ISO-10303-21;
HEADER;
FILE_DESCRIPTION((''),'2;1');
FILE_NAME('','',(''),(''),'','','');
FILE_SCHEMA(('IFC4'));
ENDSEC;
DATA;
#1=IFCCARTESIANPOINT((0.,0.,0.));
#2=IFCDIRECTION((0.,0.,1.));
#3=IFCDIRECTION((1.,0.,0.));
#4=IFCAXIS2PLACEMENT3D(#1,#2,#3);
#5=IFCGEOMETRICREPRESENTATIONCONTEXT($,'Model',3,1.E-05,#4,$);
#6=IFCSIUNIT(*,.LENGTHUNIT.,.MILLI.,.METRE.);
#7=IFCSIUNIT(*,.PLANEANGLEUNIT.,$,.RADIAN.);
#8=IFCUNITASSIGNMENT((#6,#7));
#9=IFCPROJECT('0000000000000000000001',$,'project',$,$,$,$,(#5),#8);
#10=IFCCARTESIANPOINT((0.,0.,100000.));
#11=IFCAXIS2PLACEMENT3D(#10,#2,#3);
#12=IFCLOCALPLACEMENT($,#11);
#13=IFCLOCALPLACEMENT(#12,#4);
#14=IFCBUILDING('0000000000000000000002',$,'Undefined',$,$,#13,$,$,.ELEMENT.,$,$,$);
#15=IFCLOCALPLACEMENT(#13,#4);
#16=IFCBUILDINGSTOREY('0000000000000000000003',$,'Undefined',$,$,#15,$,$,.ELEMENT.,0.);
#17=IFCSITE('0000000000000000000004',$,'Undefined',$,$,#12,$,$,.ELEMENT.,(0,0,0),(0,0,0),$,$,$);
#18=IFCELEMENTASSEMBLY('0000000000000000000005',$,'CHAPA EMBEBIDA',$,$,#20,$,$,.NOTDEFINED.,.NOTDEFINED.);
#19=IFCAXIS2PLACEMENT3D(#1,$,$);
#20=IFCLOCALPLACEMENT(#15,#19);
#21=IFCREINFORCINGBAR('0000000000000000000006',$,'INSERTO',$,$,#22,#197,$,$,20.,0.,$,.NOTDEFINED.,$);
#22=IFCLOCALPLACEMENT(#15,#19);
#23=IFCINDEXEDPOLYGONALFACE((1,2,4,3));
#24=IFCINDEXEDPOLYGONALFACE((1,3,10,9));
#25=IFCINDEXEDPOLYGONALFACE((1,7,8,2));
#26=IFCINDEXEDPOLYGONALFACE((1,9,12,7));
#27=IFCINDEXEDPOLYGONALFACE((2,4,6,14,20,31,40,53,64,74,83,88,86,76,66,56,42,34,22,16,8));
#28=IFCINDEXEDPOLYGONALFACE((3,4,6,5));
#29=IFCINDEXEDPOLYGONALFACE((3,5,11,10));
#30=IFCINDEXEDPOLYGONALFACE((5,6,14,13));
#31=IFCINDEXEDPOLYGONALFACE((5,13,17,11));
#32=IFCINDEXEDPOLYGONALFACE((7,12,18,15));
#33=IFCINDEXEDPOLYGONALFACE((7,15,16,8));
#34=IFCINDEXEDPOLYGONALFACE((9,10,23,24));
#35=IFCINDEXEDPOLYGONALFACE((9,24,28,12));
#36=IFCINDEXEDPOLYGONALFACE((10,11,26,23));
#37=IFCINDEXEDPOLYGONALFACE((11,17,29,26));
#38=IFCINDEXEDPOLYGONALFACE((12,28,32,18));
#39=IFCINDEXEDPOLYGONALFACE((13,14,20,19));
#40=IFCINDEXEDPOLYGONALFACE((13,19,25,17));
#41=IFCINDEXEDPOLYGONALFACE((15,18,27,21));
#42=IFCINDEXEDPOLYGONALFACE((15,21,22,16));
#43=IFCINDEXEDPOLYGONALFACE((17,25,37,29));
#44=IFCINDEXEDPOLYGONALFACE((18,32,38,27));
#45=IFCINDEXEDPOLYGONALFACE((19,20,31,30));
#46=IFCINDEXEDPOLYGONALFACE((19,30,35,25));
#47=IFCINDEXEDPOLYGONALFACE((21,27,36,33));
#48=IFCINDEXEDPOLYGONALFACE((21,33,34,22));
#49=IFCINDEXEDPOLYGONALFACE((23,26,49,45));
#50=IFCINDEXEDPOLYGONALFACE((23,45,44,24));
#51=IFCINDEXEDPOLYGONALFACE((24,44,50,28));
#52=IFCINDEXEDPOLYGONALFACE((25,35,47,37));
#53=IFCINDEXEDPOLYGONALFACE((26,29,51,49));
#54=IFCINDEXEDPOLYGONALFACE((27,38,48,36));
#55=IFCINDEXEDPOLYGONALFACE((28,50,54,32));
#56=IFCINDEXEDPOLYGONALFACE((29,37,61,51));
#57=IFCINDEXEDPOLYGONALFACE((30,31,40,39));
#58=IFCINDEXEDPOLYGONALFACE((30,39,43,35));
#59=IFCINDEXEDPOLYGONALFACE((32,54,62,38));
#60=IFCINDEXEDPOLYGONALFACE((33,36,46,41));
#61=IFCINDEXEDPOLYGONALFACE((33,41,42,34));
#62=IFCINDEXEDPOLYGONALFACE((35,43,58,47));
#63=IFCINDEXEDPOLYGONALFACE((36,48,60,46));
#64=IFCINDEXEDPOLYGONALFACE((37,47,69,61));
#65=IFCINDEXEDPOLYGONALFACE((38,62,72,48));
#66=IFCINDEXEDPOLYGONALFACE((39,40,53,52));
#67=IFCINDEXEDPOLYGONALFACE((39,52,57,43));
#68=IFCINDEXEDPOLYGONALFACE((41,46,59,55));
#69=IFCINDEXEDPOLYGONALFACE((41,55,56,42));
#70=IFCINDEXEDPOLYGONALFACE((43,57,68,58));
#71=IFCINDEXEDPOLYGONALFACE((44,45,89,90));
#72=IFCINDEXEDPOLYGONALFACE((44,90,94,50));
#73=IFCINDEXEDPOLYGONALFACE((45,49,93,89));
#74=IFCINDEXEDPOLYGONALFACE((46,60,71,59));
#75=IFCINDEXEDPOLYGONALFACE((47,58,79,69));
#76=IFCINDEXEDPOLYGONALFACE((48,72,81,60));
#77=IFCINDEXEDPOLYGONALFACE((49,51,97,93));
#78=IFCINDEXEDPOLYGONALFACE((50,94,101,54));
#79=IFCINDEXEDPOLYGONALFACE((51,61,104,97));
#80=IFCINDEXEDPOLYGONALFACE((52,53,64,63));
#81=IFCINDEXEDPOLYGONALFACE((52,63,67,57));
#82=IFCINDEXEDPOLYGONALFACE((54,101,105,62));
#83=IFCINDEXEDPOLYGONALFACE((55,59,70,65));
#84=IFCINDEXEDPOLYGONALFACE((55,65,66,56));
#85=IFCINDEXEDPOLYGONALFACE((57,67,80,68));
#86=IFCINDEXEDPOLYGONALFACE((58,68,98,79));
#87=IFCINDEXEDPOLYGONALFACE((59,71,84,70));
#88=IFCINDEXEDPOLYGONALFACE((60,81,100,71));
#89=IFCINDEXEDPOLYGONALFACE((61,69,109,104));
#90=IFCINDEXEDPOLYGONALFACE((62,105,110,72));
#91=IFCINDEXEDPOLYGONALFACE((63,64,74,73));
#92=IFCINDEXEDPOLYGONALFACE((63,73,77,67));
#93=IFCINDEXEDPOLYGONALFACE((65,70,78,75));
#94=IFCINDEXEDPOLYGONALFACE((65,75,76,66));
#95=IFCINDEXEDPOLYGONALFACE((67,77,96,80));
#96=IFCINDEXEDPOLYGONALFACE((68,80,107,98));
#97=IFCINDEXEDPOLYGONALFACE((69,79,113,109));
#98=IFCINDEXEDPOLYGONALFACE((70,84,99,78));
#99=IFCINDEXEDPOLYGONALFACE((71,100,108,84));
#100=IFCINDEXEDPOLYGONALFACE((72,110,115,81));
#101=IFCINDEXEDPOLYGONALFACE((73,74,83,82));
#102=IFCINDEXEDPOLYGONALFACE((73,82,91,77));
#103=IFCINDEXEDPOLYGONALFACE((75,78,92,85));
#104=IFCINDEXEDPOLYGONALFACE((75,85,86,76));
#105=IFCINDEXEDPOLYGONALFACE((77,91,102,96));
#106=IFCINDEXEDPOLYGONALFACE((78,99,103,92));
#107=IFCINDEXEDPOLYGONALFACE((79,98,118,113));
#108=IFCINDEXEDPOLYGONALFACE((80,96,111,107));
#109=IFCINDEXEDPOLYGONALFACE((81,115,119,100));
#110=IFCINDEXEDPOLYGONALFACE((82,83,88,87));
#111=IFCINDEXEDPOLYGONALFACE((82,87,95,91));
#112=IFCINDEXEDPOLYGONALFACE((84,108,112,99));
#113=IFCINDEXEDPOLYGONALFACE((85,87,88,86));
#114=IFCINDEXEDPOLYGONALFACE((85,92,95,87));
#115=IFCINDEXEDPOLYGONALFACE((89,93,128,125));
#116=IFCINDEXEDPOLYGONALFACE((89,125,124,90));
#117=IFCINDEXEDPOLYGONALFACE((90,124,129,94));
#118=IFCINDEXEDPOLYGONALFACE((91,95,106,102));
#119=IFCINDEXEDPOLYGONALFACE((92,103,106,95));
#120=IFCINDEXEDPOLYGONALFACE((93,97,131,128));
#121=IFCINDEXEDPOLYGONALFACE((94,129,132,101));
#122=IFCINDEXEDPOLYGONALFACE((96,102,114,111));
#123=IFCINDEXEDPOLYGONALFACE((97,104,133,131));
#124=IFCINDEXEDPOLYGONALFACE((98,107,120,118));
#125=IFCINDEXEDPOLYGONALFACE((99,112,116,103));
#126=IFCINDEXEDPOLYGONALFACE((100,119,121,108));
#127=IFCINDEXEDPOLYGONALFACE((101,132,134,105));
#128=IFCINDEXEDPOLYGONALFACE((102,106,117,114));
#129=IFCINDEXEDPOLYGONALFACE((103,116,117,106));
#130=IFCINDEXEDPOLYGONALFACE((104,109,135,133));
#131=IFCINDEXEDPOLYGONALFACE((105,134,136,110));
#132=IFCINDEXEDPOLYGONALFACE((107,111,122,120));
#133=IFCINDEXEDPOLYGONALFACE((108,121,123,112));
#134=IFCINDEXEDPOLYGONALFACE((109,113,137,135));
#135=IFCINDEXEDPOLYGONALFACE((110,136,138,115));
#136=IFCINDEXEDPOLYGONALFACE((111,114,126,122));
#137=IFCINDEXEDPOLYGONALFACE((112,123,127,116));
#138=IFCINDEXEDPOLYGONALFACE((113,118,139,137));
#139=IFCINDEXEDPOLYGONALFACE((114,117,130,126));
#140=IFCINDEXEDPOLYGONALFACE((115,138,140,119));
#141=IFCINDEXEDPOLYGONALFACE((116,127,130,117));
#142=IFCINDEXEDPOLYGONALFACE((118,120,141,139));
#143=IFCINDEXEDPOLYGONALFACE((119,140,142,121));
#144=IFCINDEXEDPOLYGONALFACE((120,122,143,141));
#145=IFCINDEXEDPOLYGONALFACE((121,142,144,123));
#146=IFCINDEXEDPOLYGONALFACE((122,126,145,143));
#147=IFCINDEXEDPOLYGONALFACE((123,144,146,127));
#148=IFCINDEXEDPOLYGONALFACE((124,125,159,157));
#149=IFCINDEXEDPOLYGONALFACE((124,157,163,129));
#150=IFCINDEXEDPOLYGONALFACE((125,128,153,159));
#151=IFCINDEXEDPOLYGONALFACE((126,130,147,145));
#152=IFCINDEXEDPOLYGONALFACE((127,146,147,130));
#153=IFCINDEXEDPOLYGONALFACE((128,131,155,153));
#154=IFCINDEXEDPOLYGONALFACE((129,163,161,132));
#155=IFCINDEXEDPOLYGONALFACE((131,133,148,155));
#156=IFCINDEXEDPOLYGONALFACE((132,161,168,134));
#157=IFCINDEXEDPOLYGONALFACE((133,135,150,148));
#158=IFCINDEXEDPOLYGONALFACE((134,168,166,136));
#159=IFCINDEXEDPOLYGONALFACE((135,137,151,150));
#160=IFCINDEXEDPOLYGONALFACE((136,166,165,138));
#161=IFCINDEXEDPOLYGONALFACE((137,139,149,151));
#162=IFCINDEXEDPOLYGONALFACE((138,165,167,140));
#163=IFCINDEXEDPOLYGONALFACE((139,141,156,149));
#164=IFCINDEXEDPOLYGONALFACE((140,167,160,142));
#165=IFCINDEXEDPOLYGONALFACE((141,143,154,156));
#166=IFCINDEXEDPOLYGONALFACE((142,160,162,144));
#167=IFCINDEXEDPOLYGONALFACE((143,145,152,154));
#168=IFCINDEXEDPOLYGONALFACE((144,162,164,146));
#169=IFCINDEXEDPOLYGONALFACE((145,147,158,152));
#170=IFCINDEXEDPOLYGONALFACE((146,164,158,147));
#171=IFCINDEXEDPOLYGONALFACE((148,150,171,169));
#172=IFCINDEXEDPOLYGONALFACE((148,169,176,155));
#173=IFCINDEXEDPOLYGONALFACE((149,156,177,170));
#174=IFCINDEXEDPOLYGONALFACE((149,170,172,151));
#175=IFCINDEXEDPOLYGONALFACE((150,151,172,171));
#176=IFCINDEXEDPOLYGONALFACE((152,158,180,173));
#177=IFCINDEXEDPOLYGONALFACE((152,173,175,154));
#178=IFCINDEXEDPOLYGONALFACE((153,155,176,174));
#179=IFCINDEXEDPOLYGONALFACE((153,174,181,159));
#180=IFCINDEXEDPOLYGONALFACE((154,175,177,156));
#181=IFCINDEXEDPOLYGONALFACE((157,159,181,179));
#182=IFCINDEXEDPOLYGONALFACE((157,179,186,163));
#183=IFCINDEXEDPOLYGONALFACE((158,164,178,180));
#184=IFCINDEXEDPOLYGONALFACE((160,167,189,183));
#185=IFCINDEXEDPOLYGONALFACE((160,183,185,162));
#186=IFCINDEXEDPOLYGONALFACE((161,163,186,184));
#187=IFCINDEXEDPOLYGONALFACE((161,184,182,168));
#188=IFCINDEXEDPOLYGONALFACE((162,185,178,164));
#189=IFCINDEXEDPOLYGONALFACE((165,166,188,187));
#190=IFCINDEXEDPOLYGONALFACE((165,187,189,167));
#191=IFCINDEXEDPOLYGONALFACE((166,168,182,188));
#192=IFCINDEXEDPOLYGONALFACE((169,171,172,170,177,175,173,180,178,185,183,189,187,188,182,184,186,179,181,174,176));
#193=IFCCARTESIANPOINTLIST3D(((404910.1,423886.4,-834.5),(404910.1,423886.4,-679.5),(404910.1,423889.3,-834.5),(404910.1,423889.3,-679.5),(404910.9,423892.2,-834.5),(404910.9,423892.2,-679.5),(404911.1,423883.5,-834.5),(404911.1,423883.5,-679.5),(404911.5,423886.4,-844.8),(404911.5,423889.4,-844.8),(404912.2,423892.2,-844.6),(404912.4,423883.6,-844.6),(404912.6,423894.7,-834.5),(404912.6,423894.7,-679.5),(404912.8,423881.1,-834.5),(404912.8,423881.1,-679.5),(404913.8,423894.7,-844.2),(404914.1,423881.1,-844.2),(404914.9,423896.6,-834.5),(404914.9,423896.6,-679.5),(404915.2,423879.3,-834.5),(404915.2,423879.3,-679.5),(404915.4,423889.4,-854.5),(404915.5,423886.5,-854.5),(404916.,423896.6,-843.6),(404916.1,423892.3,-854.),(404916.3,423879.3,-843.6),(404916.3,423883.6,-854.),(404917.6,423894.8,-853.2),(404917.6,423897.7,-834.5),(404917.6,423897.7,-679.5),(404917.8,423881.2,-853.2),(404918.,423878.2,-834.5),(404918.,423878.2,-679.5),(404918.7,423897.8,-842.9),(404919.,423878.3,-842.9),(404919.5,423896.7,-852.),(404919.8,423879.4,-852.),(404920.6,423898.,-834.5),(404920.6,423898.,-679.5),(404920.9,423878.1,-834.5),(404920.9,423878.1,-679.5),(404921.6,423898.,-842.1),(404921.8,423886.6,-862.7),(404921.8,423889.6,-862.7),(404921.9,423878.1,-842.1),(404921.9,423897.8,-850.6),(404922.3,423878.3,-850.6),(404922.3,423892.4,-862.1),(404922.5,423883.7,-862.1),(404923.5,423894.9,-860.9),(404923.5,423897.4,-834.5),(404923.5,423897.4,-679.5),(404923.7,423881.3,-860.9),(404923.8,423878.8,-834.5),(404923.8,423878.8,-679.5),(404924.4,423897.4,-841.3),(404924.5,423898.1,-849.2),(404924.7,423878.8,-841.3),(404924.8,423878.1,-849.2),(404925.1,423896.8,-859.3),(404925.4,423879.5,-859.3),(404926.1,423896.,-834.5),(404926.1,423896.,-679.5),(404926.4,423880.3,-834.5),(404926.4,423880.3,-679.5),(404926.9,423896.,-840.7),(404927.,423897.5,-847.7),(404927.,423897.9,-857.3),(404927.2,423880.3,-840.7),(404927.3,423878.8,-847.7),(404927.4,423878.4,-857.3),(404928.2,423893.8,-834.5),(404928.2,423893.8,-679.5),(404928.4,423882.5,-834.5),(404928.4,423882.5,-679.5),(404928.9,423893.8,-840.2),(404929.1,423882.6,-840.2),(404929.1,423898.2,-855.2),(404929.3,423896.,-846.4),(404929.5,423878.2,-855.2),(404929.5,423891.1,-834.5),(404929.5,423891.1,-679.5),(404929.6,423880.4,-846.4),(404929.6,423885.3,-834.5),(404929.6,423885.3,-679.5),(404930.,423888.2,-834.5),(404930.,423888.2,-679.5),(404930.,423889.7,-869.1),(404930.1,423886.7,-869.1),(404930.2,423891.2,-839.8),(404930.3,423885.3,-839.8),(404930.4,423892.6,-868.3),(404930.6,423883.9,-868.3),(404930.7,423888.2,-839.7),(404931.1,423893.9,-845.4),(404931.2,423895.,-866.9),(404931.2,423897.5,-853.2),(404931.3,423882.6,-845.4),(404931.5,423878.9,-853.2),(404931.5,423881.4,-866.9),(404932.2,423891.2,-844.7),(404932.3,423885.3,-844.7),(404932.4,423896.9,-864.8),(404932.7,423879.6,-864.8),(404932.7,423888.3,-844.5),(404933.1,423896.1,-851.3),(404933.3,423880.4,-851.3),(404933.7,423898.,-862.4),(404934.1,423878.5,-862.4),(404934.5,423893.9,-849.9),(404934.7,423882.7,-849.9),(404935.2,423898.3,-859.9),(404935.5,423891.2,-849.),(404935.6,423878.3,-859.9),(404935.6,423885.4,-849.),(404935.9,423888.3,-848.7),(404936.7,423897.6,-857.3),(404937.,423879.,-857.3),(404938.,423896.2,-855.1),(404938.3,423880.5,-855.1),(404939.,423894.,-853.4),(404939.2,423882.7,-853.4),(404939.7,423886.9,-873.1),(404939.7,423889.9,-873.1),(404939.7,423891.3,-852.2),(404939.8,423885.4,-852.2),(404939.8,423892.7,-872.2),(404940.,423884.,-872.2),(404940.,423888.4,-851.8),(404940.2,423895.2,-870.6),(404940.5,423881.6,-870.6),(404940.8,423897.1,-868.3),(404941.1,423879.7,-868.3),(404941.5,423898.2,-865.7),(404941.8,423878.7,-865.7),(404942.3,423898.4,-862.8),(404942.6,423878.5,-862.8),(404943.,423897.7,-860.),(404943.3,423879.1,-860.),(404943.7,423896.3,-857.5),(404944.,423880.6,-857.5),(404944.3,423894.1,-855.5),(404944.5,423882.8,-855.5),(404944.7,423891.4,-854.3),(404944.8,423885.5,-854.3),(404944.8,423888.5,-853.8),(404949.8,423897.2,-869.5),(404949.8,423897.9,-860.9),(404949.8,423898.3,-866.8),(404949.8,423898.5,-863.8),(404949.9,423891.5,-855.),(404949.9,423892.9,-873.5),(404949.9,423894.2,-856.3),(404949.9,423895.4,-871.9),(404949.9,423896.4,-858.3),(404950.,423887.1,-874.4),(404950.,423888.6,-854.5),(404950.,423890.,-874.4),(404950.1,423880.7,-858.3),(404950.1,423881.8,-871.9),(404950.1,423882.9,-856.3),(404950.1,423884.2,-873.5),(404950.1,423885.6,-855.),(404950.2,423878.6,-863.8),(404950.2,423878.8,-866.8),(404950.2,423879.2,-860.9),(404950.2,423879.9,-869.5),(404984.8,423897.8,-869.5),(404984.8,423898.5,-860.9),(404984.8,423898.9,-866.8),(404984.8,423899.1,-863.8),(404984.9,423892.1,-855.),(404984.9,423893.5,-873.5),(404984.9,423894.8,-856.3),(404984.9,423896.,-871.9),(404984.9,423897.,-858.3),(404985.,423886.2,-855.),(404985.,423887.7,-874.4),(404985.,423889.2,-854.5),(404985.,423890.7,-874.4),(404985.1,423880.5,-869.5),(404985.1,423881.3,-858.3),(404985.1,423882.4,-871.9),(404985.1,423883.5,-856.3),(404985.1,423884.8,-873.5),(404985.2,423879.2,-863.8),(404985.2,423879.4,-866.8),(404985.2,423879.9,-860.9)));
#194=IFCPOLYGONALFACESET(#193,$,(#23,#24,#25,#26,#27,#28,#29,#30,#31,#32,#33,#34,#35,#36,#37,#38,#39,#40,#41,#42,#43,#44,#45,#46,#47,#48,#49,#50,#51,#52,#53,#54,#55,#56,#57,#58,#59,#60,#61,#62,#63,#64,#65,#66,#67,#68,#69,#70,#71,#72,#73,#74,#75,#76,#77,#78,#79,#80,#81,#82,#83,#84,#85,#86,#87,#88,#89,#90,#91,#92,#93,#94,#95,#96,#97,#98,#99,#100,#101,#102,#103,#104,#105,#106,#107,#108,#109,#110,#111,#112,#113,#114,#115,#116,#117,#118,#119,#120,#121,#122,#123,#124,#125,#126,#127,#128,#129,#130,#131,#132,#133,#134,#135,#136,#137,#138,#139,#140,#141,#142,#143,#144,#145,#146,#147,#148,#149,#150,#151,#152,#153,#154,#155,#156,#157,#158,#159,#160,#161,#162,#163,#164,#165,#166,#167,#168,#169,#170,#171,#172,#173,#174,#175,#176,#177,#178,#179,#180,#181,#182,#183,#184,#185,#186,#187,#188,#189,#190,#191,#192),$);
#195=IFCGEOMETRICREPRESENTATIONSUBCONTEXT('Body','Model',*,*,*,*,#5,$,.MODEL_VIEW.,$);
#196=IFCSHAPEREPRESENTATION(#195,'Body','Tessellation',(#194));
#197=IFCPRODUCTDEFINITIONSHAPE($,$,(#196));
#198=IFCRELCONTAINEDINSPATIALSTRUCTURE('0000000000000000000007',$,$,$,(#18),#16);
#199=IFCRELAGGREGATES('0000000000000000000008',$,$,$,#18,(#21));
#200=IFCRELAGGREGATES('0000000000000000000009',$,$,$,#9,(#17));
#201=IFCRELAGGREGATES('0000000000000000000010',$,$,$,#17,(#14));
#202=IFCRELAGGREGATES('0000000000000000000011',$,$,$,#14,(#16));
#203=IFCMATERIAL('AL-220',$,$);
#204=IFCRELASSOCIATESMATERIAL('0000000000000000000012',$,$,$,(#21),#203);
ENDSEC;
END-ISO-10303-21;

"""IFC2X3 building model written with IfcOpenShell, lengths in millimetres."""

from ifc_helpers import new_model, entity, si_unit, frame, origin_with_axes, place, context, subcontext, project, spatial, source, transform, mapped, material, element, aggregate, save


model = new_model("IFC2X3")

# Units and contexts
model_context = context("Model", 3, precision=1e-05, world=origin_with_axes())
body_context = subcontext(model_context, "Body", "Model", "MODEL_VIEW")
ifc_project = project(units=[si_unit("LENGTHUNIT", "METRE", prefix="MILLI"), si_unit("PLANEANGLEUNIT", "RADIAN")], contexts=[model_context])

# Site, building, storey
site_placement = place(None, frame((0.0, 0.0, 100000.0), z_axis=(0.0, 0.0, 1.0), x_axis=(1.0, 0.0, 0.0)))
site = spatial("IfcSite", under=ifc_project, at=site_placement, Name="Undefined", CompositionType="ELEMENT", RefLatitude=(0, 0, 0), RefLongitude=(0, 0, 0))
building_placement = place(site_placement, origin_with_axes())
building = spatial("IfcBuilding", under=site, at=building_placement, Name="Undefined", CompositionType="ELEMENT")
storey_placement = place(building_placement, origin_with_axes())
storey = spatial("IfcBuildingStorey", under=building, at=storey_placement, Name="Undefined", CompositionType="ELEMENT", Elevation=0.0)

# Element assembly
assembly_1_placement = place(storey_placement, origin_with_axes())
assembly_1 = element("IfcElementAssembly", 1, at=assembly_1_placement, inside=storey, Name="CHAPA EMBEBIDA", AssemblyPlace="NOTDEFINED", PredefinedType="NOTDEFINED")

# Reinforcing bar
ifc_material_1 = material(Name="AL-220")
shared_shape_1 = source(origin_with_axes(), body_context, "Body", "AdvancedSweptSolid", [
    entity("IfcSweptDiskSolid", entity("IfcCompositeCurve", [entity("IfcCompositeCurveSegment", "CONTINUOUS", True, entity("IfcTrimmedCurve", entity("IfcLine", entity("IfcCartesianPoint", [0.0, 0.0, 0.0]), entity("IfcVector", entity("IfcDirection", [1.0, 0.0, 0.0]), 1.0)), [entity("IfcParameterValue", 0.0)], [entity("IfcParameterValue", 155.0)], True, "PARAMETER")), entity("IfcCompositeCurveSegment", "CONTINUOUS", True, entity("IfcTrimmedCurve", entity("IfcCircle", entity("IfcAxis2Placement3D", entity("IfcCartesianPoint", [155.0, 0.0, 30.0]), entity("IfcDirection", [0.0, -1.0, 0.0]), entity("IfcDirection", [0.0, 0.0, -1.0])), 30.0), [entity("IfcParameterValue", 0.0)], [entity("IfcParameterValue", 1.570796)], True, "PARAMETER")), entity("IfcCompositeCurveSegment", "DISCONTINUOUS", True, entity("IfcTrimmedCurve", entity("IfcLine", entity("IfcCartesianPoint", [185.0, 0.0, 30.0]), entity("IfcVector", entity("IfcDirection", [0.0, 0.0, 1.0]), 1.0)), [entity("IfcParameterValue", 0.0)], [entity("IfcParameterValue", 35.0)], True, "PARAMETER"))], False), 10.0, None, 0.0, 191.6),
])
reinforcing_bar_1_placement = place(assembly_1_placement, frame((404920.0, 423888.0, -679.5), z_axis=(0.999848, 0.017452, 0.0), x_axis=(0.0, 0.0, -1.0)))
reinforcing_bar_1 = element("IfcReinforcingBar", 2, at=reinforcing_bar_1_placement, material=ifc_material_1, Name="INSERTO", BarRole="NOTDEFINED", CrossSectionArea=0.0, NominalDiameter=20.0, context=body_context, shape_type="MappedRepresentation", body=[
    mapped(shared_shape_1, transform((0.0, 0.0, 0.0))),
])
aggregate(assembly_1, [reinforcing_bar_1])

save(model, "model.ifc")
